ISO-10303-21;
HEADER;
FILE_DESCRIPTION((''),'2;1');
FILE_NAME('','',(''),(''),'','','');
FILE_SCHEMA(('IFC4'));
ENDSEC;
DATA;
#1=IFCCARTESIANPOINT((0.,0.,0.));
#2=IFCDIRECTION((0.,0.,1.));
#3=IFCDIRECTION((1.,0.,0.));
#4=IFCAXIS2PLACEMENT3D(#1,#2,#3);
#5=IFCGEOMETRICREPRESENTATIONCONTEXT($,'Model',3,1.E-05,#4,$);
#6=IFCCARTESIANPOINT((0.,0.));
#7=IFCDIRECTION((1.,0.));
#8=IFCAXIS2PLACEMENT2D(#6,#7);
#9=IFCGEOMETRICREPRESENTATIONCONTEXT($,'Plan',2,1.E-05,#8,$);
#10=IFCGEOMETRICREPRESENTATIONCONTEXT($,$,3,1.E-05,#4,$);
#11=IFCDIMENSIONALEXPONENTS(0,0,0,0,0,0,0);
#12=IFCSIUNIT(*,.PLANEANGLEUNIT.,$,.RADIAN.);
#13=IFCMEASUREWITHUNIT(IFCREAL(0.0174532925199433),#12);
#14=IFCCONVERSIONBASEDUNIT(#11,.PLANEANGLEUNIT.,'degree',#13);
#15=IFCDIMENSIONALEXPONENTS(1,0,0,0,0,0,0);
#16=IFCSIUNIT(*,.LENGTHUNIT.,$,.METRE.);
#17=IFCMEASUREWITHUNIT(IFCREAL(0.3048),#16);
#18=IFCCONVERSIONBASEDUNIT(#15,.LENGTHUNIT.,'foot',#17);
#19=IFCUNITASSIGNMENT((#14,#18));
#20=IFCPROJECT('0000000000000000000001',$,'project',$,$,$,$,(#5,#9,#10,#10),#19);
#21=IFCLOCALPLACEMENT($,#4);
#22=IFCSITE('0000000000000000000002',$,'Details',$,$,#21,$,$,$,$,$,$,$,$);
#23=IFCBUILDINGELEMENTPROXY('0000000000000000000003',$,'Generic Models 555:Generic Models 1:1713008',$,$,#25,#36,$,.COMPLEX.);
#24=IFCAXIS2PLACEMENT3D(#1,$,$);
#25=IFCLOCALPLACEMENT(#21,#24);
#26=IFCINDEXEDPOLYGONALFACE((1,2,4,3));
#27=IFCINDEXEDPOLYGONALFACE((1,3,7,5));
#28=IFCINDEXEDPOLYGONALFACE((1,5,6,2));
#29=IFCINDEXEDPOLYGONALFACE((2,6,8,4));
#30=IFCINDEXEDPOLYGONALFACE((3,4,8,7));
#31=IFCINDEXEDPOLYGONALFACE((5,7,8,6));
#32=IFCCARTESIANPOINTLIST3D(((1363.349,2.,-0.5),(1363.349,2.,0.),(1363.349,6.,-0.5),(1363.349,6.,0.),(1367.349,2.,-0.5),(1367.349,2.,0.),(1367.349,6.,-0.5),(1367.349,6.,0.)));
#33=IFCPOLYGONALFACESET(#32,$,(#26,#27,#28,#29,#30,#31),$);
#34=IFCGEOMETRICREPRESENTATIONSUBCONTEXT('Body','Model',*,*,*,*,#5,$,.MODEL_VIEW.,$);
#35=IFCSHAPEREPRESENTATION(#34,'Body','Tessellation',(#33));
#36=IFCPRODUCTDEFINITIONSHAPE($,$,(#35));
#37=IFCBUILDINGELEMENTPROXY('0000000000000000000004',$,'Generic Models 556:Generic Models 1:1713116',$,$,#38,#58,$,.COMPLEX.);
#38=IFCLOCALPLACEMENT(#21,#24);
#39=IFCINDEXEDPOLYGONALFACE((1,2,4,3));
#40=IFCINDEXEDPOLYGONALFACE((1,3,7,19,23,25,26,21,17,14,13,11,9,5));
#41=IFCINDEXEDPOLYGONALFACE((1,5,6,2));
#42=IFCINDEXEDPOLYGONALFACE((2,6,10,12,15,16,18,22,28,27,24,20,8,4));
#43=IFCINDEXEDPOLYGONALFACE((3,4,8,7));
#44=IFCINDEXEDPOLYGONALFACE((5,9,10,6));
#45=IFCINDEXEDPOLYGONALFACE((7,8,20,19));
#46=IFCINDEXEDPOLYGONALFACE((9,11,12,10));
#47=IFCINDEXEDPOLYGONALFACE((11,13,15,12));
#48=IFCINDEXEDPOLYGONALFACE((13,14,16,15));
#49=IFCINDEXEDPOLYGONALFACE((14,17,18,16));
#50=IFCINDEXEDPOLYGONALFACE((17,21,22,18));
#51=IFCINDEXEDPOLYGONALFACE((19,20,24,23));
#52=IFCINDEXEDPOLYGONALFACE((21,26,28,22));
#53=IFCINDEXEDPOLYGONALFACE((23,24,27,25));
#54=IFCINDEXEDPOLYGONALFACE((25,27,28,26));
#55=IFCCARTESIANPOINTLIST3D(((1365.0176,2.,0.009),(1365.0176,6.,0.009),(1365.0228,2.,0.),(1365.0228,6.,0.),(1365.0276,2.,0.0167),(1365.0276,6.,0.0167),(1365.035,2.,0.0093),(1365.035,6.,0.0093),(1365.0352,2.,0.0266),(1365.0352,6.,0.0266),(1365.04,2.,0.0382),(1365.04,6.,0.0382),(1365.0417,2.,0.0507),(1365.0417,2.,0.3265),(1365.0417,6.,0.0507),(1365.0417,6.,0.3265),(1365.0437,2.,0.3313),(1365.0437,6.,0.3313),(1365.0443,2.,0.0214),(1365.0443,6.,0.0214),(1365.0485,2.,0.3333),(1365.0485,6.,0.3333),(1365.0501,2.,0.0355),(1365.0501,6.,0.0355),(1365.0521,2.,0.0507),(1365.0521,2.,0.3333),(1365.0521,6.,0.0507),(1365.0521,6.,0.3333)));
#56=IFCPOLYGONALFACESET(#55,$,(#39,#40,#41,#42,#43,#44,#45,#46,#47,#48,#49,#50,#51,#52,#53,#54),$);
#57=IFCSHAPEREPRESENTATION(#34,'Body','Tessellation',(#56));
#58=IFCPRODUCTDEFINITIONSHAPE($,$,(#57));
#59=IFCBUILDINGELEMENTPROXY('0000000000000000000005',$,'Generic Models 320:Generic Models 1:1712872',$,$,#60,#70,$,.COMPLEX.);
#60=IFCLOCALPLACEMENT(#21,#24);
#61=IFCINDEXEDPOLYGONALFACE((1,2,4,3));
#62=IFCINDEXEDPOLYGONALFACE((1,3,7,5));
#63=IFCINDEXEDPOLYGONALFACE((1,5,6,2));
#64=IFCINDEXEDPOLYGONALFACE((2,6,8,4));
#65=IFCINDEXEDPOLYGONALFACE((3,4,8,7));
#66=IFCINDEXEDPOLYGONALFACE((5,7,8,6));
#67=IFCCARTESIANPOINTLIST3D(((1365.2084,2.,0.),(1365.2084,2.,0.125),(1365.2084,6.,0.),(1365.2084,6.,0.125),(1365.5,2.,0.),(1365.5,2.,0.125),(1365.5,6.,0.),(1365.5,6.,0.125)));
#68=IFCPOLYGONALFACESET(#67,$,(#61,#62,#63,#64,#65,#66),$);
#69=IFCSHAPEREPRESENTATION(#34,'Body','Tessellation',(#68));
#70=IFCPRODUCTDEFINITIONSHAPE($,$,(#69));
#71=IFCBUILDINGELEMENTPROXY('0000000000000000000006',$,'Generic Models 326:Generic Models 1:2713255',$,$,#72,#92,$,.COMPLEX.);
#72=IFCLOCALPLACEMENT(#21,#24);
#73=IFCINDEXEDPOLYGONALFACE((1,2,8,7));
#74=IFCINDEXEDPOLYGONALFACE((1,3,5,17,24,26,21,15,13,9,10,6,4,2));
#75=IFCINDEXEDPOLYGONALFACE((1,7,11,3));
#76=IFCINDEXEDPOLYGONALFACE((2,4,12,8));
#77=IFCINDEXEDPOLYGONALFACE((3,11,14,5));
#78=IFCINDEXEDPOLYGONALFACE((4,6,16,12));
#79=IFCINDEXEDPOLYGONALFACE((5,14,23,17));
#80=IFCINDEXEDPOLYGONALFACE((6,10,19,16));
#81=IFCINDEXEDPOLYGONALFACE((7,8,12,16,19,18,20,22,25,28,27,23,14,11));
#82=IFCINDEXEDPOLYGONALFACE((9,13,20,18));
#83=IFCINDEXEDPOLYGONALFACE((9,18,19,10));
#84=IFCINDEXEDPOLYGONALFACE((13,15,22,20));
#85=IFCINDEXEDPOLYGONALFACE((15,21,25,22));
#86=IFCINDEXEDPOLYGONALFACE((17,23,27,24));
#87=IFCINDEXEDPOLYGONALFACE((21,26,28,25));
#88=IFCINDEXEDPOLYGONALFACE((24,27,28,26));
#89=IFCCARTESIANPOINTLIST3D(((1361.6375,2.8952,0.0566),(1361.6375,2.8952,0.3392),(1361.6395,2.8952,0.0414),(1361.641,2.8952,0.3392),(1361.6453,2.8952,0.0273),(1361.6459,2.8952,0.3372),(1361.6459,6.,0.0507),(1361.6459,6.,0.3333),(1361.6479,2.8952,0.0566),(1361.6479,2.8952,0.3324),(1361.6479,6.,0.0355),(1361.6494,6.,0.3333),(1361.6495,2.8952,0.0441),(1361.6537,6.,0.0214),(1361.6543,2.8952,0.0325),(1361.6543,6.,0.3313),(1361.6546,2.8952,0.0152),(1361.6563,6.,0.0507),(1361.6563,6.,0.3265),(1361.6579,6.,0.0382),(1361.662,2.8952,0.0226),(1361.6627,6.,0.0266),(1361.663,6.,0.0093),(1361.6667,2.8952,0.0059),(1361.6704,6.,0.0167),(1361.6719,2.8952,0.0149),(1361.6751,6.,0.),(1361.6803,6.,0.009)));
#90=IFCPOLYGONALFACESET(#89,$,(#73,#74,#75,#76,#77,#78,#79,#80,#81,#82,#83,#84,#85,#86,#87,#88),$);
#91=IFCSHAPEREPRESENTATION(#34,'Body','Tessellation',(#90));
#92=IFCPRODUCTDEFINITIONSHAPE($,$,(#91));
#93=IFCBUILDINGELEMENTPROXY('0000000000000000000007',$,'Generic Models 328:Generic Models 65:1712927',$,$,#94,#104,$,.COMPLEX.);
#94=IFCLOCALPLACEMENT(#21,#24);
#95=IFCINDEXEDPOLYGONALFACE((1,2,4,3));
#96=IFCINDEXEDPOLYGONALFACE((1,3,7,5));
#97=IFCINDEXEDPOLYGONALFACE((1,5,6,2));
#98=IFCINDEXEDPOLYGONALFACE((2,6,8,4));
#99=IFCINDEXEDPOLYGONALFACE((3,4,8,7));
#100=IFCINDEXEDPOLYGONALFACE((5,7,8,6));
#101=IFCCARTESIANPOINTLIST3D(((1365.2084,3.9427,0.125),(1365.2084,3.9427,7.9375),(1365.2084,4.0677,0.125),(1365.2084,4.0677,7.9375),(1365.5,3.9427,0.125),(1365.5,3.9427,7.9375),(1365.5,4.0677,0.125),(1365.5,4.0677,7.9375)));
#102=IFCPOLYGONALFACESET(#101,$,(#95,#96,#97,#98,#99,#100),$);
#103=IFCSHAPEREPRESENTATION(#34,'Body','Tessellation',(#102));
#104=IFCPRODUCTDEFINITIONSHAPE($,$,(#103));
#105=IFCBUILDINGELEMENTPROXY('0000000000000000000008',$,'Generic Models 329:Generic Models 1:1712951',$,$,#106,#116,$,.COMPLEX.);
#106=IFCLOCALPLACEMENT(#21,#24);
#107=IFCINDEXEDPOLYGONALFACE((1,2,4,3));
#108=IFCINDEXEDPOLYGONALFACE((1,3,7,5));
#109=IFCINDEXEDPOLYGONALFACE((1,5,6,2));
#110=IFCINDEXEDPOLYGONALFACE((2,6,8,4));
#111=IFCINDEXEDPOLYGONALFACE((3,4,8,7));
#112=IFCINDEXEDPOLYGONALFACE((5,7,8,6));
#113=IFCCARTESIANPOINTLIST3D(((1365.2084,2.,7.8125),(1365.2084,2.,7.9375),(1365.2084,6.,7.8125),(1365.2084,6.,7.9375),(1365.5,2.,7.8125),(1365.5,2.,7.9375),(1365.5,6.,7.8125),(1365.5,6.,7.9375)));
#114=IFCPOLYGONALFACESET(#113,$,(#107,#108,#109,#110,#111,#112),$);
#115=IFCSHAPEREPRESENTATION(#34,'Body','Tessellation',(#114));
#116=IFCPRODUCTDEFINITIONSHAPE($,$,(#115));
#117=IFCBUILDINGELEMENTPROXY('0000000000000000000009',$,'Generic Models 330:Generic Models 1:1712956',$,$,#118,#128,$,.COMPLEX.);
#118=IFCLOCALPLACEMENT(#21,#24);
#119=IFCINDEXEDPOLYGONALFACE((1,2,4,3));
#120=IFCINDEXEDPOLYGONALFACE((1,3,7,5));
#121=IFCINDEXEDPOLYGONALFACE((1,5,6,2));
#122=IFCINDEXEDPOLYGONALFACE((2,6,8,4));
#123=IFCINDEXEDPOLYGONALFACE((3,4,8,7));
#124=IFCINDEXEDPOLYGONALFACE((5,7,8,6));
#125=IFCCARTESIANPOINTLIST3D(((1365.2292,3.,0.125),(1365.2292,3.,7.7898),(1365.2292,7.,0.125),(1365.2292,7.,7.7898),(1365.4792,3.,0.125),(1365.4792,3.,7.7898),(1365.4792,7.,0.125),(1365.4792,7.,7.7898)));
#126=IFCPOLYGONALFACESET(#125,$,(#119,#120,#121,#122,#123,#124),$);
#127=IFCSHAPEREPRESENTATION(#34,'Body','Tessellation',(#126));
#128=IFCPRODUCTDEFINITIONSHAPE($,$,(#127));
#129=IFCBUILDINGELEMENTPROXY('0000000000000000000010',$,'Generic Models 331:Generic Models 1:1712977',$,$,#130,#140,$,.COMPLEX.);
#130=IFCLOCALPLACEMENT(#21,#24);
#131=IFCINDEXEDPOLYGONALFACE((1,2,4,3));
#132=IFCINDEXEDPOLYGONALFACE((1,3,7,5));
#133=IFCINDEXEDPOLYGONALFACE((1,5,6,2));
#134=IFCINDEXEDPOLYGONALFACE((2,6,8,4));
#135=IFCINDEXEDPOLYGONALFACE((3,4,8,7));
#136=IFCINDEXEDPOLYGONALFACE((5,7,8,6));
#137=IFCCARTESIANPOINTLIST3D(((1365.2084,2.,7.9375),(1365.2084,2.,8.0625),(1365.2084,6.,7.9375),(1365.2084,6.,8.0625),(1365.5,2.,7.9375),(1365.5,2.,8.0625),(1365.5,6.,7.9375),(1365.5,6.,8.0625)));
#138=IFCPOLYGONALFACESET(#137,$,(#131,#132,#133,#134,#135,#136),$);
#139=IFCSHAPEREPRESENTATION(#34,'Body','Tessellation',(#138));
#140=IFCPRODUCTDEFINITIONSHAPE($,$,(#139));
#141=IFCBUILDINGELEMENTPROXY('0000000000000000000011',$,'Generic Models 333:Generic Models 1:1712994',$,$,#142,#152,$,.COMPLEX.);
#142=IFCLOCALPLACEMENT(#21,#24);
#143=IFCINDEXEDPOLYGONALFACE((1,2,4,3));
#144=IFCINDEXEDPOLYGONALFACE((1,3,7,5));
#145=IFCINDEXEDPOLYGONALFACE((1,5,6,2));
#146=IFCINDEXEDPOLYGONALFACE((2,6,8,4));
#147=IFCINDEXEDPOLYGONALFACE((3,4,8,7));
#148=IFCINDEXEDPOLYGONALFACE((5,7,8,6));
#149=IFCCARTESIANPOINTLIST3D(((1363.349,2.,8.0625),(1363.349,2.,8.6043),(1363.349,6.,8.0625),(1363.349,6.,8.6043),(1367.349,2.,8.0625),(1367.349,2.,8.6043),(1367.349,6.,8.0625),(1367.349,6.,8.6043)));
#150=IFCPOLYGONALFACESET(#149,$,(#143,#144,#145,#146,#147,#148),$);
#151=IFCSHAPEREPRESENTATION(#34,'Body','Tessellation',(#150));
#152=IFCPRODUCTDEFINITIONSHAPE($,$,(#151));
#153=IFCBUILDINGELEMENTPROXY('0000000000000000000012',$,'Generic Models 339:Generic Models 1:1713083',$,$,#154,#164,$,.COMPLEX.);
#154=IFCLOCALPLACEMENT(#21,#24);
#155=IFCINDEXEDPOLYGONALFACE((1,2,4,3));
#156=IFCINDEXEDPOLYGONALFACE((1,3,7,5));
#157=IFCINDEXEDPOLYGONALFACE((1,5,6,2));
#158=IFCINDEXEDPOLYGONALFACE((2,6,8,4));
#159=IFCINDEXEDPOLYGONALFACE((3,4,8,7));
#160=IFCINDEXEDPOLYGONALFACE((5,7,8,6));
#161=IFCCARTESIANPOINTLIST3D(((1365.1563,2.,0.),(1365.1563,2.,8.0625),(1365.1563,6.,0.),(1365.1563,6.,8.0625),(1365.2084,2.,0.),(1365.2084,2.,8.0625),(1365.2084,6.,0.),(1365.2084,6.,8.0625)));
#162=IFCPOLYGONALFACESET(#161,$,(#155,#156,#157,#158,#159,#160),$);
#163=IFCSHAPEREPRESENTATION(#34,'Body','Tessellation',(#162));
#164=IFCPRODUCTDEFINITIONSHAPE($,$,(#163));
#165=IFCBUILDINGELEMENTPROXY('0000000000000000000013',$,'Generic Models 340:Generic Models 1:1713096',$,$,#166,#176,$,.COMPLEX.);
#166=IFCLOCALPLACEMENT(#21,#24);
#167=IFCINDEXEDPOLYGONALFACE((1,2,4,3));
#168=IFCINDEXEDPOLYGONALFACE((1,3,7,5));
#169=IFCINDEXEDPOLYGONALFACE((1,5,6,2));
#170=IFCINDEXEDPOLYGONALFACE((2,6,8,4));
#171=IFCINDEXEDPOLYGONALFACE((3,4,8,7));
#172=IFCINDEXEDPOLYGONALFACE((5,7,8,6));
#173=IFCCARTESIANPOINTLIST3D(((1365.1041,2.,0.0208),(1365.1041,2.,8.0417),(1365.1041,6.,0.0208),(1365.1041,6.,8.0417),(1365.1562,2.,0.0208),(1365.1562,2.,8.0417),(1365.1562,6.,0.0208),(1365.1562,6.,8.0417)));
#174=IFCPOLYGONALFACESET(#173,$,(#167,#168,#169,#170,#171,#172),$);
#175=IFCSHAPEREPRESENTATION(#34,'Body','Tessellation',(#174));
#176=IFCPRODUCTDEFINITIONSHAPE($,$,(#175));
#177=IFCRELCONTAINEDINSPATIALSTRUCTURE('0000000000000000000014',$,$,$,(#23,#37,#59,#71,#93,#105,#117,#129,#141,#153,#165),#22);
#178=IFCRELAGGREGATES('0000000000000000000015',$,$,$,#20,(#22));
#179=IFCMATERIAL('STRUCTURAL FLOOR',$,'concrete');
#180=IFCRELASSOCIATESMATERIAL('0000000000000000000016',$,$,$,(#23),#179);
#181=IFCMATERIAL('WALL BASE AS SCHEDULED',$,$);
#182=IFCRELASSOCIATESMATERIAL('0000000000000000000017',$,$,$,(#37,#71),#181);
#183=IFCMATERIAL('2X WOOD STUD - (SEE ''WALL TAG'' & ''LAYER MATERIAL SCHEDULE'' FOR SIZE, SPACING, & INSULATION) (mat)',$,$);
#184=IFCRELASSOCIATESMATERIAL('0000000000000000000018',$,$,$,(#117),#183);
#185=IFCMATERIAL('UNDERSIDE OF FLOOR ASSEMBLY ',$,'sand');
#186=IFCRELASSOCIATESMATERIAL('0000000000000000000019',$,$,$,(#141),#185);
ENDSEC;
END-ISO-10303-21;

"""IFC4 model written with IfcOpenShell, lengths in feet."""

from ifc_helpers import new_model, entity, si_unit, converted_unit, frame, origin_with_axes, origin_2d_with_axis, place, context, subcontext, project, spatial, polyline, outline, extrude, material, element, save


model = new_model("IFC4")

# Units and contexts
model_context = context("Model", 3, precision=1e-05, world=origin_with_axes())
plan_context = context("Plan", 2, precision=1e-05, world=origin_2d_with_axis())
context_of_model = context(None, 3, precision=1e-05, world=origin_with_axes())
body_context = subcontext(model_context, "Body", "Model", "MODEL_VIEW")
ifc_project = project(units=[converted_unit("PLANEANGLEUNIT", "degree", entity("IfcReal", 0.0174532925199433), si_unit("PLANEANGLEUNIT", "RADIAN"), dimensions=[0, 0, 0, 0, 0, 0, 0]), converted_unit("LENGTHUNIT", "foot", entity("IfcReal", 0.3048), si_unit("LENGTHUNIT", "METRE"), dimensions=[1, 0, 0, 0, 0, 0, 0])], contexts=[model_context, plan_context, context_of_model, context_of_model])

# Site
site_placement = place(None, origin_with_axes())
site = spatial("IfcSite", under=ifc_project, at=site_placement, Name="Details")

# Building element proxies
ifc_material_1 = material(Name="STRUCTURAL FLOOR", Category="concrete")
proxy_1_placement = place(site_placement, frame((1363.349, 6.0, -0.5), z_axis=(0.0, -1.0, 0.0), x_axis=(0.0, 0.0, 1.0)))
element("IfcBuildingElementProxy", 1, at=proxy_1_placement, inside=site, material=ifc_material_1, Name="Generic Models 555:Generic Models 1:1713008", PredefinedType="COMPLEX", context=body_context, shape_type="SweptSolid", body=[
    extrude(outline(polyline([(-0.25, -2.0), (0.25, -2.0), (0.25, 2.0), (-0.25, 2.0), (-0.25, -2.0)])), frame((0.25, -2.0, 0.0), z_axis=(0.0, 0.0, -1.0), x_axis=(1.0, 0.0, 0.0)), (0.0, 0.0, -1.0), 4.0),
])
ifc_material_2 = material(Name="WALL BASE AS SCHEDULED")
proxy_2_placement = place(site_placement, frame((1365.0176, 6.0, 0.0), z_axis=(0.0, -1.0, 0.0), x_axis=(0.0, 0.0, 1.0)))
element("IfcBuildingElementProxy", 2, at=proxy_2_placement, inside=site, material=ifc_material_2, Name="Generic Models 556:Generic Models 1:1713116", PredefinedType="COMPLEX", context=body_context, shape_type="SweptSolid", body=[
    extrude(outline(polyline([(0.2205, 0.0), (0.2206, 0.0036), (-0.0618, 0.0152), (-0.077, 0.0138), (-0.0914, 0.0086), (-0.1038, -0.0002), (-0.1136, -0.012), (-0.1048, -0.0175), (-0.0968, -0.0079), (-0.0865, -0.0007), (-0.0747, 0.0037), (-0.0622, 0.0048), (0.2133, -0.0066), (0.2183, -0.0048), (0.2205, 0.0)])), frame((0.113, -0.0218, 0.0), z_axis=(0.0, 0.0, -1.0), x_axis=(0.999153, -0.041137, 0.0)), (0.0, 0.0, -1.0), 4.0),
])
proxy_3_placement = place(site_placement, frame((1365.2084, 6.0, 0.0), z_axis=(0.0, -1.0, 0.0), x_axis=(0.0, 0.0, 1.0)))
element("IfcBuildingElementProxy", 3, at=proxy_3_placement, inside=site, Name="Generic Models 320:Generic Models 1:1712872", PredefinedType="COMPLEX", context=body_context, shape_type="SweptSolid", body=[
    extrude(outline(polyline([(-0.0625, -0.1458), (0.0625, -0.1458), (0.0625, 0.1458), (-0.0625, 0.1458), (-0.0625, -0.1458)])), frame((0.0625, -0.1458, 0.0), z_axis=(0.0, 0.0, -1.0), x_axis=(1.0, 0.0, 0.0)), (0.0, 0.0, -1.0), 4.0),
])
proxy_4_placement = place(site_placement, frame((1361.6459, 6.0, 0.0), z_axis=(0.0, -1.0, 0.0), x_axis=(0.0, 0.0, 1.0)))
element("IfcBuildingElementProxy", 4, at=proxy_4_placement, inside=site, material=ifc_material_2, Name="Generic Models 326:Generic Models 1:2713255", PredefinedType="COMPLEX", context=body_context, shape_type="SweptSolid", body=[
    extrude(outline(polyline([(-0.2134, 0.0022), (0.0624, 0.0022), (0.0748, 0.0006), (0.0864, -0.0042), (0.0964, -0.0119), (0.104, -0.0218), (0.113, -0.0166), (0.1037, -0.0045), (0.0916, 0.0048), (0.0775, 0.0106), (0.0624, 0.0126), (-0.2203, 0.0126), (-0.2203, 0.0091), (-0.2183, 0.0042), (-0.2134, 0.0022)])), frame((0.113, -0.0126, 0.0), z_axis=(0.0, 0.0, -1.0), x_axis=(-1.0, 0.0, 0.0)), (-0.001902, 0.002712, -0.999995), 3.1048),
])
proxy_5_placement = place(site_placement, frame((1365.2084, 3.9427, 0.125), z_axis=(0.0, 0.0, 1.0), x_axis=(1.0, 0.0, 0.0)))
element("IfcBuildingElementProxy", 5, at=proxy_5_placement, inside=site, Name="Generic Models 328:Generic Models 65:1712927", PredefinedType="COMPLEX", context=body_context, shape_type="SweptSolid", body=[
    extrude(outline(polyline([(-0.1458, -0.0625), (0.1458, -0.0625), (0.1458, 0.0625), (-0.1458, 0.0625), (-0.1458, -0.0625)])), frame((0.1458, 0.0625, 0.0), z_axis=(0.0, 0.0, -1.0), x_axis=(-1.0, 0.0, 0.0)), (0.0, 0.0, -1.0), 7.8125),
])
proxy_6_placement = place(site_placement, frame((1365.2084, 6.0, 7.8125), z_axis=(0.0, -1.0, 0.0), x_axis=(0.0, 0.0, 1.0)))
element("IfcBuildingElementProxy", 6, at=proxy_6_placement, inside=site, Name="Generic Models 329:Generic Models 1:1712951", PredefinedType="COMPLEX", context=body_context, shape_type="SweptSolid", body=[
    extrude(outline(polyline([(-0.1458, -0.0625), (0.1458, -0.0625), (0.1458, 0.0625), (-0.1458, 0.0625), (-0.1458, -0.0625)])), frame((0.0625, -0.1458, 0.0), z_axis=(0.0, 0.0, -1.0), x_axis=(0.0, 1.0, 0.0)), (0.0, 0.0, -1.0), 4.0),
])
ifc_material_3 = material(Name="2X WOOD STUD - (SEE 'WALL TAG' & 'LAYER MATERIAL SCHEDULE' FOR SIZE, SPACING, & INSULATION) (mat)")
proxy_7_placement = place(site_placement, frame((1365.2292, 3.0, 0.125), z_axis=(0.0, 0.0, 1.0), x_axis=(0.0, 1.0, 0.0)))
element("IfcBuildingElementProxy", 7, at=proxy_7_placement, inside=site, material=ifc_material_3, Name="Generic Models 330:Generic Models 1:1712956", PredefinedType="COMPLEX", context=body_context, shape_type="SweptSolid", body=[
    extrude(outline(polyline([(-2.0, -0.125), (2.0, -0.125), (2.0, 0.125), (-2.0, 0.125), (-2.0, -0.125)])), frame((2.0, -0.125, 0.0), z_axis=(0.0, 0.0, -1.0), x_axis=(1.0, 0.0, 0.0)), (0.0, 0.0, -1.0), 7.6648),
])
proxy_8_placement = place(site_placement, frame((1365.2084, 6.0, 7.9375), z_axis=(0.0, -1.0, 0.0), x_axis=(0.0, 0.0, 1.0)))
element("IfcBuildingElementProxy", 8, at=proxy_8_placement, inside=site, Name="Generic Models 331:Generic Models 1:1712977", PredefinedType="COMPLEX", context=body_context, shape_type="SweptSolid", body=[
    extrude(outline(polyline([(-0.1458, -0.0625), (0.1458, -0.0625), (0.1458, 0.0625), (-0.1458, 0.0625), (-0.1458, -0.0625)])), frame((0.0625, -0.1458, 0.0), z_axis=(0.0, 0.0, -1.0), x_axis=(0.0, 1.0, 0.0)), (0.0, 0.0, -1.0), 4.0),
])
ifc_material_4 = material(Name="UNDERSIDE OF FLOOR ASSEMBLY ", Category="sand")
proxy_9_placement = place(site_placement, frame((1363.349, 6.0, 8.0625), z_axis=(0.0, -1.0, 0.0), x_axis=(0.0, 0.0, 1.0)))
element("IfcBuildingElementProxy", 9, at=proxy_9_placement, inside=site, material=ifc_material_4, Name="Generic Models 333:Generic Models 1:1712994", PredefinedType="COMPLEX", context=body_context, shape_type="SweptSolid", body=[
    extrude(outline(polyline([(-0.2709, -2.0), (0.2709, -2.0), (0.2709, 2.0), (-0.2709, 2.0), (-0.2709, -2.0)])), frame((0.2709, -2.0, 0.0), z_axis=(0.0, 0.0, -1.0), x_axis=(1.0, 0.0, 0.0)), (0.0, 0.0, -1.0), 4.0),
])
proxy_10_placement = place(site_placement, frame((1365.1563, 6.0, 0.0), z_axis=(0.0, -1.0, 0.0), x_axis=(0.0, 0.0, 1.0)))
element("IfcBuildingElementProxy", 10, at=proxy_10_placement, inside=site, Name="Generic Models 339:Generic Models 1:1713083", PredefinedType="COMPLEX", context=body_context, shape_type="SweptSolid", body=[
    extrude(outline(polyline([(-4.0312, -0.026), (4.0312, -0.026), (4.0312, 0.026), (-4.0312, 0.026), (-4.0312, -0.026)])), frame((4.0312, -0.026, 0.0), z_axis=(0.0, 0.0, -1.0), x_axis=(-1.0, 0.0, 0.0)), (0.0, 0.0, -1.0), 4.0),
])
proxy_11_placement = place(site_placement, frame((1365.1041, 6.0, 0.0208), z_axis=(0.0, -1.0, 0.0), x_axis=(0.0, 0.0, 1.0)))
element("IfcBuildingElementProxy", 11, at=proxy_11_placement, inside=site, Name="Generic Models 340:Generic Models 1:1713096", PredefinedType="COMPLEX", context=body_context, shape_type="SweptSolid", body=[
    extrude(outline(polyline([(-0.026, -4.0104), (0.026, -4.0104), (0.026, 4.0104), (-0.026, 4.0104), (-0.026, -4.0104)])), frame((4.0104, -0.026, 0.0), z_axis=(0.0, 0.0, -1.0), x_axis=(0.0, 1.0, 0.0)), (0.0, 0.0, -1.0), 4.0),
])

save(model, "model.ifc")
